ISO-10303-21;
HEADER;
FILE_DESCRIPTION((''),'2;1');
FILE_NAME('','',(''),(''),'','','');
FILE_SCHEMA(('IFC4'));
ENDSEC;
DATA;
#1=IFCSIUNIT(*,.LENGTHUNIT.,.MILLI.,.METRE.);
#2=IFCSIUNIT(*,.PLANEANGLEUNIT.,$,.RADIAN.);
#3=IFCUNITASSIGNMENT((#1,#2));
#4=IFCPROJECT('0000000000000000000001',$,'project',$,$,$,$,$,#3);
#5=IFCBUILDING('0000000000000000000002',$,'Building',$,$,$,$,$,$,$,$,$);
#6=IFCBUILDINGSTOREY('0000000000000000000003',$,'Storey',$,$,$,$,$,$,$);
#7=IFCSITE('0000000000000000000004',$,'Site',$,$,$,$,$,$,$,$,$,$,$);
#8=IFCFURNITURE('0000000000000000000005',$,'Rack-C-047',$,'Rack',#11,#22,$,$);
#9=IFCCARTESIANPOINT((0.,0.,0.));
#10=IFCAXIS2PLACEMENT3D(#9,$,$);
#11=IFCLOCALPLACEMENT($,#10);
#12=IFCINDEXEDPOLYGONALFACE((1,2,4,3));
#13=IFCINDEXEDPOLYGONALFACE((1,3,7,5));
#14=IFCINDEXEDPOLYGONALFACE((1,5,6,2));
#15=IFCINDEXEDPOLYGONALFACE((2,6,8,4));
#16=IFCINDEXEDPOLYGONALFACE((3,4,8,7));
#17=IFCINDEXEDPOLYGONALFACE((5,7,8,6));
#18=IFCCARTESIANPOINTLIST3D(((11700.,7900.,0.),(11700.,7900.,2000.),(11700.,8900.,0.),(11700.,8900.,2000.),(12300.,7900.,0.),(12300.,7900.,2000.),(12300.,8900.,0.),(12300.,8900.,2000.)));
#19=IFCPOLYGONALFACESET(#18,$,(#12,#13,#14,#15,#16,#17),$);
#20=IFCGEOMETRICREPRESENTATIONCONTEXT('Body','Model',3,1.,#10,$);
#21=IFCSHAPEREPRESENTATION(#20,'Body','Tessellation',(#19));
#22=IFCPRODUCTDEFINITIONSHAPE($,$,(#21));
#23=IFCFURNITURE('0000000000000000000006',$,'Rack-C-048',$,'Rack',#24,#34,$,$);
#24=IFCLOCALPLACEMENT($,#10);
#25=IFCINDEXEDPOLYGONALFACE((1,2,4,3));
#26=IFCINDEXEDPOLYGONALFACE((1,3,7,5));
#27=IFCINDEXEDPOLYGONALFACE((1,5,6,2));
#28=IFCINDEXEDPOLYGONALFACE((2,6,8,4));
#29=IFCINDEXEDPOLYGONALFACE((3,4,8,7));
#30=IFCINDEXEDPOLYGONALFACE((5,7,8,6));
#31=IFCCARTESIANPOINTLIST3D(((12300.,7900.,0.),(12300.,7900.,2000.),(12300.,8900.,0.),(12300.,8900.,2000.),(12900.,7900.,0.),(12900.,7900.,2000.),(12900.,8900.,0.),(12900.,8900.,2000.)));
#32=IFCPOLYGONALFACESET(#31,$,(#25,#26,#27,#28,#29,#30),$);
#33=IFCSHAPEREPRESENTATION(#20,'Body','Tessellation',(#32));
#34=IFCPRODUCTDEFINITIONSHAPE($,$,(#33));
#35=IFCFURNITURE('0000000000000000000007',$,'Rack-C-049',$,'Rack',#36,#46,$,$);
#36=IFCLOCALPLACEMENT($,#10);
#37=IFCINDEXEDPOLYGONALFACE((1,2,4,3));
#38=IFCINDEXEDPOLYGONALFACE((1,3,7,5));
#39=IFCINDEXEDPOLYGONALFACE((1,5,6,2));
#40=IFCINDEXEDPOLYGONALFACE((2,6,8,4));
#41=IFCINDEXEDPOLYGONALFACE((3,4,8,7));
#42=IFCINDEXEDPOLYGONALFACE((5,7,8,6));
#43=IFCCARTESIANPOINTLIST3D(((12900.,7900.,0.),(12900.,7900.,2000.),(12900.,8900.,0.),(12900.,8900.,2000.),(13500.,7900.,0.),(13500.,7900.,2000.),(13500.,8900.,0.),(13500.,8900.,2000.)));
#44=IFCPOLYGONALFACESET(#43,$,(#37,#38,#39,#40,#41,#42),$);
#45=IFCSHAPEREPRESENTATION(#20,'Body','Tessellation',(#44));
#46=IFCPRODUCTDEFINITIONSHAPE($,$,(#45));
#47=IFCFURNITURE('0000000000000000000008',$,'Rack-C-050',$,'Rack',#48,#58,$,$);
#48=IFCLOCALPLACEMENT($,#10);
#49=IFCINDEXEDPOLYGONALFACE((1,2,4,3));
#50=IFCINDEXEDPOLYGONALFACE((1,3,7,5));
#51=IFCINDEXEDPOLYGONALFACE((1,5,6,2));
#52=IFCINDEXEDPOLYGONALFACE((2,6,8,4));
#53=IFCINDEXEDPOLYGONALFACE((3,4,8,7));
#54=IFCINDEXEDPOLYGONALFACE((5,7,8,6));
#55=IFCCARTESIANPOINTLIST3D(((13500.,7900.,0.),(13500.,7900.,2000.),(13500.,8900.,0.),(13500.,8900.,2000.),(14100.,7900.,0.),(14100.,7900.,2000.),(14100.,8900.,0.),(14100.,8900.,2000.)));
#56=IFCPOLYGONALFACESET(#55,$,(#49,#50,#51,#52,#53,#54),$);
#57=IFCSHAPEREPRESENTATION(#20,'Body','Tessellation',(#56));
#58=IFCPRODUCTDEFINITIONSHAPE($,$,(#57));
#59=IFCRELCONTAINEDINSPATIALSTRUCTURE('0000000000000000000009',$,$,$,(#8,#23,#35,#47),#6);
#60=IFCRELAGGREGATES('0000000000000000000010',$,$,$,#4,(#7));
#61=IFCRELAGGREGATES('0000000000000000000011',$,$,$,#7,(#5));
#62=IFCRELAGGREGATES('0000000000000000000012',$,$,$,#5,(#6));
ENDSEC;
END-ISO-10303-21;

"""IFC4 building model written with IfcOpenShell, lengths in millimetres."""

from ifc_helpers import new_model, si_unit, frame, origin, place, context, project, spatial, rectangle, extrude, element, save


model = new_model("IFC4")

# Units and contexts
model_context = context("Model", 3, precision=1.0, world=origin(), identifier="Body")
ifc_project = project(units=[si_unit("LENGTHUNIT", "METRE", prefix="MILLI"), si_unit("PLANEANGLEUNIT", "RADIAN")])

# Site, building, storey
site = spatial("IfcSite", under=ifc_project, Name="Site")
building = spatial("IfcBuilding", under=site, Name="Building")
storey = spatial("IfcBuildingStorey", under=building, Name="Storey")

# Furniture
for number, where, z_axis, x_axis, name in (
    (1, (12000.0, 8400.0, 0.0), (0.0, 0.0, 1.0), (1.0, 0.0, 0.0), "Rack-C-047"),
    (2, (12600.0, 8400.0, 0.0), (0.0, 0.0, 1.0), (1.0, 0.0, 0.0), "Rack-C-048"),
    (3, (13200.0, 8400.0, 0.0), (0.0, 0.0, 1.0), (1.0, 0.0, 0.0), "Rack-C-049"),
    (4, (13800.0, 8400.0, 0.0), (0.0, 0.0, 1.0), (1.0, 0.0, 0.0), "Rack-C-050"),
):
    element("IfcFurniture", number, at=place(None, frame(where, z_axis=z_axis, x_axis=x_axis)), inside=storey, Name=name, ObjectType="Rack", context=model_context, shape_type="SweptSolid", body=[
        extrude(rectangle(XDim=600.0, YDim=1000.0), origin(), (0.0, 0.0, 1.0), 2000.0),
    ])

save(model, "model.ifc")
